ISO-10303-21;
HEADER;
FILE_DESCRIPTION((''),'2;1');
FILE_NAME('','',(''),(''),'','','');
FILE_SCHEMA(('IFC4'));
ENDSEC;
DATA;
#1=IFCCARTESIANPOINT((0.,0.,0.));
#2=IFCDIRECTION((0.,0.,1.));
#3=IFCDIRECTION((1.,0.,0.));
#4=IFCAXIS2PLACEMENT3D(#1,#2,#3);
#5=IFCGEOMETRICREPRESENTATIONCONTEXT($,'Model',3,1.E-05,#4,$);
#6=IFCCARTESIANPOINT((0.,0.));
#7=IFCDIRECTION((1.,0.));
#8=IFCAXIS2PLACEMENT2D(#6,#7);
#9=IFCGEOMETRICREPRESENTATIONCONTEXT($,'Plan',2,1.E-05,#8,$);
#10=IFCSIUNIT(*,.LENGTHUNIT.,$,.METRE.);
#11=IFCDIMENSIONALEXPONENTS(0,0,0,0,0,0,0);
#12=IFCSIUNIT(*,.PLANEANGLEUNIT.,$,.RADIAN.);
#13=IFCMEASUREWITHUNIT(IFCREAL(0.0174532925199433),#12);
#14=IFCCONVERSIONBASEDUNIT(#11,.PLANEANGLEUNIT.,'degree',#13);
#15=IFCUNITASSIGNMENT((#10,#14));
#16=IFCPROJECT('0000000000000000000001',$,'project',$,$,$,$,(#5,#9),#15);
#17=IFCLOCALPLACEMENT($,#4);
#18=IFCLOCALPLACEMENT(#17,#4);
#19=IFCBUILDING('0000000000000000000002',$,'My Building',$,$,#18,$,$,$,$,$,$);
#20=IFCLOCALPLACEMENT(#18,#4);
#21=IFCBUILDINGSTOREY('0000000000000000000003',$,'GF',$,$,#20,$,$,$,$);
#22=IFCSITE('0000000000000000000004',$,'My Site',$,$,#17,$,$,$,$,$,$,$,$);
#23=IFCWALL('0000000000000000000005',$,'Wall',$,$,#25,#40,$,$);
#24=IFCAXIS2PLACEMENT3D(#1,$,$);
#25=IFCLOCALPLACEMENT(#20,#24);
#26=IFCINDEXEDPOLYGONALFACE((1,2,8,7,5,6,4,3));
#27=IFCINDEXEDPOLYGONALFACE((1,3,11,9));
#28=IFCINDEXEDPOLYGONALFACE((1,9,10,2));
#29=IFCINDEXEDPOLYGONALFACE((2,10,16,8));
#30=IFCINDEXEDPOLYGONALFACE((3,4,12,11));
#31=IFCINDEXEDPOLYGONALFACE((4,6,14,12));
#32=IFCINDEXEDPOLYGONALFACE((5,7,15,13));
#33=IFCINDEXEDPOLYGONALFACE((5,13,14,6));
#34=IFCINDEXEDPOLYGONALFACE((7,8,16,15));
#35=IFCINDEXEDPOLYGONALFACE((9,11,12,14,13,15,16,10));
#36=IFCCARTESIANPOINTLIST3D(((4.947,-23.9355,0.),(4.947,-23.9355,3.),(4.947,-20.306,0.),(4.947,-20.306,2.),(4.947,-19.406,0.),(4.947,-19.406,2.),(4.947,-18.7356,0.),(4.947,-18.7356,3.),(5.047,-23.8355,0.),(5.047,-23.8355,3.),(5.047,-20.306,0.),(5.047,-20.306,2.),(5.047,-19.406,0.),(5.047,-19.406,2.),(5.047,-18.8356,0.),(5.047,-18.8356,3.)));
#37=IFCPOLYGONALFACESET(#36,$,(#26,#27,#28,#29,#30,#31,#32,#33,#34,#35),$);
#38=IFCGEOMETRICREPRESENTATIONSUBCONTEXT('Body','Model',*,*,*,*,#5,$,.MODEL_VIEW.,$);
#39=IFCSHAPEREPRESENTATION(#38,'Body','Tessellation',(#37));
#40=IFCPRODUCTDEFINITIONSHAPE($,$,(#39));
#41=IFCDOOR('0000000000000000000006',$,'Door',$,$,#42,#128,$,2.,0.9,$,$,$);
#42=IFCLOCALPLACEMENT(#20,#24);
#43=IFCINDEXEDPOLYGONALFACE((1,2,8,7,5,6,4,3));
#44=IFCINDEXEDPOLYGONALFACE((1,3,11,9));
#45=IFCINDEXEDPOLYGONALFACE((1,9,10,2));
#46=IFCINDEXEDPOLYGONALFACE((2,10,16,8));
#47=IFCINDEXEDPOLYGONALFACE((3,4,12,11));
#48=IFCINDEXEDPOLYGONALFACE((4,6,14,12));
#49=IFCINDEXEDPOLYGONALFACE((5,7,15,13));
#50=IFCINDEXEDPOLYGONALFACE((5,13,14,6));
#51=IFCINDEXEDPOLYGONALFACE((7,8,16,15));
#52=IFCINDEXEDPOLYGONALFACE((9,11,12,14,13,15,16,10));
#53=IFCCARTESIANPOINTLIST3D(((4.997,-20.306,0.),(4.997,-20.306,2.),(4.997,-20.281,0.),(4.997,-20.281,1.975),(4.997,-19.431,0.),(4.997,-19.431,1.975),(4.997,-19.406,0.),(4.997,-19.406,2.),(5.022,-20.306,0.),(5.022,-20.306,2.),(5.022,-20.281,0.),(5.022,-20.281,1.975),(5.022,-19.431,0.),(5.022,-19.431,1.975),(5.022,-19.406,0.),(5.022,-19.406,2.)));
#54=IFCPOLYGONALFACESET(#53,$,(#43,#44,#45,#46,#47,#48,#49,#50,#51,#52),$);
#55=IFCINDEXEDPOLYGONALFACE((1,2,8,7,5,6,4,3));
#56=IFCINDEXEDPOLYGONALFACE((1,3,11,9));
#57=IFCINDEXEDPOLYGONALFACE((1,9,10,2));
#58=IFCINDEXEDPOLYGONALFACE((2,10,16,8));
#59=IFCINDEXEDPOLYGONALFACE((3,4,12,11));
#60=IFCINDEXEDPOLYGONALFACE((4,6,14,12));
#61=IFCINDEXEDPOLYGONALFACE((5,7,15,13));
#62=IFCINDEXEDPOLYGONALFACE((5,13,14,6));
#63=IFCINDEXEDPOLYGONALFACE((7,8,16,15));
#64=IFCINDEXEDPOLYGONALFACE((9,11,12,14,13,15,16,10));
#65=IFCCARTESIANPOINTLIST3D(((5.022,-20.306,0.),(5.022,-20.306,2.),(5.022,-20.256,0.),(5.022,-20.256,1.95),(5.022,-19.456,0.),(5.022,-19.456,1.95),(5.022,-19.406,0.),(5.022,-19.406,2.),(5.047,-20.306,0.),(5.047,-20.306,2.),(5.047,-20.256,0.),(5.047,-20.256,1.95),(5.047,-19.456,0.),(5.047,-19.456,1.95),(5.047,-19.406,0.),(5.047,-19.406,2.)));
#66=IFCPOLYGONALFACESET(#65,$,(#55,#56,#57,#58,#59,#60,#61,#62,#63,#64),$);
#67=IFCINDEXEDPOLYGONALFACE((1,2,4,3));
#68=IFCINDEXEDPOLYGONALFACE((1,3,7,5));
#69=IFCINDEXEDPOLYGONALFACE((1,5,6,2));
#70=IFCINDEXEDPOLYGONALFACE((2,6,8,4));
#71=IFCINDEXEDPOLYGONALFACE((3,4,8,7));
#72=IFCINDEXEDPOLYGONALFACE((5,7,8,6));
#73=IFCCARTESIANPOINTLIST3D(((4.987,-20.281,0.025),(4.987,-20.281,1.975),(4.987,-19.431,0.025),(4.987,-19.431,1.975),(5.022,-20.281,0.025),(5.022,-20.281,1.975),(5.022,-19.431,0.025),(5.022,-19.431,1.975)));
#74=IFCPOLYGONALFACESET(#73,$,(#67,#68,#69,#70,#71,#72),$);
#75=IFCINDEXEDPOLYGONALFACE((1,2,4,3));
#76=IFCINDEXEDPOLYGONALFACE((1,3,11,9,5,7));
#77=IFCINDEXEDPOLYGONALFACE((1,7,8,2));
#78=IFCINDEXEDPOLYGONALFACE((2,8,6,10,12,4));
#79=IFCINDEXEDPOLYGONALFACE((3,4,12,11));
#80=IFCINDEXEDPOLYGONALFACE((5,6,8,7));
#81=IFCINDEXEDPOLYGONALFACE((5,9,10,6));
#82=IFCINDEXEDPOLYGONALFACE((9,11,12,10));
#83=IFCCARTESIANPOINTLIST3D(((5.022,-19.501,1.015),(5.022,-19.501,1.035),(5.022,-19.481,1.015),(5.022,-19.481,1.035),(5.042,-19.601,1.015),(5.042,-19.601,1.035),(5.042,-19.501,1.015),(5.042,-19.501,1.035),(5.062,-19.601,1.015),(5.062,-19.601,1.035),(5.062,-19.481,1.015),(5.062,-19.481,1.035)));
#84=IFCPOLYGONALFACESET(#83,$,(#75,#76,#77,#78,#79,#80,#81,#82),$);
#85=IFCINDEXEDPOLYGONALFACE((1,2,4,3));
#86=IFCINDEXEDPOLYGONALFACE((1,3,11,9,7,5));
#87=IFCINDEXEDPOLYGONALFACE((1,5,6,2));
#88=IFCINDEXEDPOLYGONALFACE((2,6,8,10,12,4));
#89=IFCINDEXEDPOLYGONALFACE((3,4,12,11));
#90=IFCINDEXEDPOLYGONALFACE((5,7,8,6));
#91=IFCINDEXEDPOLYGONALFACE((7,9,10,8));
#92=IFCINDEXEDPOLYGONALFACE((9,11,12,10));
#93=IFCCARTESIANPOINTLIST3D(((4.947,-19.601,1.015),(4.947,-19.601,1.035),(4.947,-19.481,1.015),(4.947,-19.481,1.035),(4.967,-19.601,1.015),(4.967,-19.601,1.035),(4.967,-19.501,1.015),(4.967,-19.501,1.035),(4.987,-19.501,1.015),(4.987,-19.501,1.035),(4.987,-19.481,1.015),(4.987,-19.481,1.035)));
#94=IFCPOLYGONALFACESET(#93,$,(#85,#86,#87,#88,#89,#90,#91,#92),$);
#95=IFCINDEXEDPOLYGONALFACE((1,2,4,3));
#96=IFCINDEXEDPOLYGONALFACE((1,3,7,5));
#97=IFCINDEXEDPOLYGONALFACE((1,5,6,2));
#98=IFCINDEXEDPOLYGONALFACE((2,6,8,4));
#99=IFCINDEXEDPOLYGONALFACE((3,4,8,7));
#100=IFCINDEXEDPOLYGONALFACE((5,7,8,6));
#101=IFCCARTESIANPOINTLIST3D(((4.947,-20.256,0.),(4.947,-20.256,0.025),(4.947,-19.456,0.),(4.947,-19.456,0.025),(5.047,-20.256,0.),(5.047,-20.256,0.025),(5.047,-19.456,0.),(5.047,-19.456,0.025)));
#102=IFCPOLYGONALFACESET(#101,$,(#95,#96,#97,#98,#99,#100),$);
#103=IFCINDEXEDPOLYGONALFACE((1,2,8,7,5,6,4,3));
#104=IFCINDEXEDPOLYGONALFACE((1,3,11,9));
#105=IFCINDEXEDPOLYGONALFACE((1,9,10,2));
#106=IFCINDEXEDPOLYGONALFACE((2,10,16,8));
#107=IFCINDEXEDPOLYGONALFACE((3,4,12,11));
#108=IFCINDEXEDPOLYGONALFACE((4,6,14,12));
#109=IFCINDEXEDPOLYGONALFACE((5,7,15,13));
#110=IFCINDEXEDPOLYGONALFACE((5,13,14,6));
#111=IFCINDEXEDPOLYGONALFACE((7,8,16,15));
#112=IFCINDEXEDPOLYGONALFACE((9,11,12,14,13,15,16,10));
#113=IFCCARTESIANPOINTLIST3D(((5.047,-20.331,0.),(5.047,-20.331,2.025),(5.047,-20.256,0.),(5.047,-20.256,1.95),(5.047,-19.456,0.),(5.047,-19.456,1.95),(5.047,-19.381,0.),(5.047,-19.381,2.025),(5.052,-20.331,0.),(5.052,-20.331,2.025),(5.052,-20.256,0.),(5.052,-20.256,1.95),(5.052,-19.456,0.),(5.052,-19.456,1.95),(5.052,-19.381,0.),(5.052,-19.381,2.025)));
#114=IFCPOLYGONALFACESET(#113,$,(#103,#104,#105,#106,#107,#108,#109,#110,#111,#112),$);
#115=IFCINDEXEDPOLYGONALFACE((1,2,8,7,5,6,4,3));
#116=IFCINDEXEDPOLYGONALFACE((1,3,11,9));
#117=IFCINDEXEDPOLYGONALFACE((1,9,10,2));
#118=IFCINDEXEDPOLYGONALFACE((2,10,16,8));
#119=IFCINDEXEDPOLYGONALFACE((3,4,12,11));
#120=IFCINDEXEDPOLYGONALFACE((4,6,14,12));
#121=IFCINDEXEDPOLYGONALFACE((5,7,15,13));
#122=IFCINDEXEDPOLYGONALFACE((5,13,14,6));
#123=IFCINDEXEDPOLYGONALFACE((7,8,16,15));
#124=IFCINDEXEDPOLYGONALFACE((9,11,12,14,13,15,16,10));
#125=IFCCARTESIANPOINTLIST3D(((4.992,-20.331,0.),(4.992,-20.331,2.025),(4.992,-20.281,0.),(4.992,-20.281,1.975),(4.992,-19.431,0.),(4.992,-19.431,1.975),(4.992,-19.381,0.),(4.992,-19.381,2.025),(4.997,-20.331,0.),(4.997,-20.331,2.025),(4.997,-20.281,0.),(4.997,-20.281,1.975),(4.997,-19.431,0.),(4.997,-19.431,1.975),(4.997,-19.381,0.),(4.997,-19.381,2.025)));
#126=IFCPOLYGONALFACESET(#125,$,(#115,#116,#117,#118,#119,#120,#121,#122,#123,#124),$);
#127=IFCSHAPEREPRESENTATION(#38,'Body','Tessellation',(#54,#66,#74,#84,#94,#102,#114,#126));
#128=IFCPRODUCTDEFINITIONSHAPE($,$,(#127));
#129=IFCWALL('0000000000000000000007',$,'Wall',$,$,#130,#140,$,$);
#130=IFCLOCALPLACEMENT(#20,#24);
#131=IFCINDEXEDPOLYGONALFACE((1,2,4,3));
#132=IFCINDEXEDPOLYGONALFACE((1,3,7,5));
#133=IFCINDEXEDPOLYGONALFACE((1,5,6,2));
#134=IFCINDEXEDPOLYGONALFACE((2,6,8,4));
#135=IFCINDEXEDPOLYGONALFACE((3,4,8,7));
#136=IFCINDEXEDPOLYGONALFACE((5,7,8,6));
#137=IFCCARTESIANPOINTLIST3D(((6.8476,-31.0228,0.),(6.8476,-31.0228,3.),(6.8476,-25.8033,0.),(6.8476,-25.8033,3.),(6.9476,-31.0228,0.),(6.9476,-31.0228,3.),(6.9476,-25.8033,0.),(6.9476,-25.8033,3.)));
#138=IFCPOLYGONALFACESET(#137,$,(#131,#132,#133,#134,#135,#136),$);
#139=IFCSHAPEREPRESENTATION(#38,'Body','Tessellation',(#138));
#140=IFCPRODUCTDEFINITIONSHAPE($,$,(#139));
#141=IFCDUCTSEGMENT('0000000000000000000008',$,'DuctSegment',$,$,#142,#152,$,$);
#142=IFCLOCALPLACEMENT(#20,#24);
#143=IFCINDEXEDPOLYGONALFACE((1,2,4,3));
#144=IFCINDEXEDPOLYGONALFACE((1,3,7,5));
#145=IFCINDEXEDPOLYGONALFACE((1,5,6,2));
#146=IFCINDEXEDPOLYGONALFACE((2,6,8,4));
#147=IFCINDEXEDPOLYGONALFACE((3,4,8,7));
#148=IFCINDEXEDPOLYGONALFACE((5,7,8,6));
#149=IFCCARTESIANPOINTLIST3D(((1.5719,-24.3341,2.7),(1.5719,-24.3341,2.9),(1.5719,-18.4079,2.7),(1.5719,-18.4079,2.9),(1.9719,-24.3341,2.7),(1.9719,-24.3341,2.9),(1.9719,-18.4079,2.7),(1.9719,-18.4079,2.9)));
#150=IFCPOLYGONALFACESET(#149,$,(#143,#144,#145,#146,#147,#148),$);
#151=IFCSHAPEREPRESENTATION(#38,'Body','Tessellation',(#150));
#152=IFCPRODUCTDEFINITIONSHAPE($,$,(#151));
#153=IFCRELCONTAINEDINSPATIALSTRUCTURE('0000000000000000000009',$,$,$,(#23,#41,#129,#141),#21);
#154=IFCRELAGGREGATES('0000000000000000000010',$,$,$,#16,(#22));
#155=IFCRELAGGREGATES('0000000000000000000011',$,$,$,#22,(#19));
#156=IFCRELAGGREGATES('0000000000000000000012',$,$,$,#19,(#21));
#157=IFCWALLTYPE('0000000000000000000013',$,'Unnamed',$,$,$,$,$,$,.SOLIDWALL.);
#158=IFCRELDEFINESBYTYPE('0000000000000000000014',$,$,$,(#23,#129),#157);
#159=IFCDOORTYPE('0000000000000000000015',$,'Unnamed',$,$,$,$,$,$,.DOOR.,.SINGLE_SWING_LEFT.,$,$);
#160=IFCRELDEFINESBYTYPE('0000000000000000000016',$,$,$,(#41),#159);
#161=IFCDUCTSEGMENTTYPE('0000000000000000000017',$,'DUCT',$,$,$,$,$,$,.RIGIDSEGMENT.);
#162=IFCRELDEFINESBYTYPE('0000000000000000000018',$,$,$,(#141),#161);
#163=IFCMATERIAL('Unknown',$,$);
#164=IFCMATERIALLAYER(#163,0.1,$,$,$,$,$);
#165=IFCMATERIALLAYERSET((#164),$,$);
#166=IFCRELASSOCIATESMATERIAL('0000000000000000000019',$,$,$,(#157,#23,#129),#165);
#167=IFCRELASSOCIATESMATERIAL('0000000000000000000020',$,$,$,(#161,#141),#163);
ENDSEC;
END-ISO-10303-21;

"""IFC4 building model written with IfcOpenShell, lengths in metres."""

from ifc_helpers import new_model, entity, si_unit, converted_unit, frame, origin_with_axes, origin_2d_with_axis, place, context, subcontext, project, spatial, line, indexed_curve, rectangle, outline, extrude, shape, source, transform, mapped, material, layer, layer_set, layer_usage, material_profile, profile_set, profile_usage, type_object, type_shapes, element, fill, save


model = new_model("IFC4")

# Units and contexts
model_context = context("Model", 3, precision=1e-05, world=origin_with_axes())
plan_context = context("Plan", 2, precision=1e-05, world=origin_2d_with_axis())
body_context_1 = subcontext(model_context, "Body", "Model", "MODEL_VIEW")
body_context_2 = subcontext(plan_context, "Body", "Plan", "PLAN_VIEW")
ifc_project = project(units=[si_unit("LENGTHUNIT", "METRE"), converted_unit("PLANEANGLEUNIT", "degree", entity("IfcReal", 0.0174532925199433), si_unit("PLANEANGLEUNIT", "RADIAN"), dimensions=[0, 0, 0, 0, 0, 0, 0])], contexts=[model_context, plan_context])

# Site, building, storey
site_placement = place(None, origin_with_axes())
site = spatial("IfcSite", under=ifc_project, at=site_placement, Name="My Site")
building_placement = place(site_placement, origin_with_axes())
building = spatial("IfcBuilding", under=site, at=building_placement, Name="My Building")
storey_placement = place(building_placement, origin_with_axes())
storey = spatial("IfcBuildingStorey", under=building, at=storey_placement, Name="GF")

# Shared definitions
ifc_material = material(Name="Unknown")

# Shared definitions
ifc_layer_1 = layer(ifc_material, 0.1)
ifc_layer_set_1 = layer_set([ifc_layer_1])
wall_type = type_object("IfcWallType", Name="Unnamed", PredefinedType="SOLIDWALL", material=ifc_layer_set_1)

# Shared definitions
shared_shape_1 = source(origin_with_axes(), body_context_1, "Body", "SweptSolid", [
    extrude(outline(indexed_curve([(0.0, 0.0), (0.9, 0.0), (0.9, 2.0), (0.0, 2.0)], segments=[line(1, 2, 3, 4, 1)])), frame((0.0, -0.6, 0.0), z_axis=(0.0, -1.0, 0.0), x_axis=(1.0, 0.0, 0.0)), (0.0, 0.0, -1.0), 1.2),
])
door_type = type_object("IfcDoorType", Name="Unnamed", OperationType="SINGLE_SWING_LEFT", PredefinedType="DOOR")
shared_shape_2 = source(origin_with_axes(), body_context_1, "Body", "SweptSolid", [
    extrude(outline(indexed_curve([(0.0, 0.0), (0.0, 2.0), (0.9, 2.0), (0.9, 0.0), (0.875, 0.0), (0.875, 1.975), (0.025, 1.975), (0.025, 0.0)], segments=[line(1, 2, 3, 4, 5, 6, 7, 8, 1)])), frame((0.0, 0.025, 0.0), z_axis=(0.0, -1.0, 0.0), x_axis=(1.0, 0.0, 0.0)), (0.0, 0.0, -1.0), 0.025),
    extrude(outline(indexed_curve([(0.0, 0.0), (0.0, 2.0), (0.9, 2.0), (0.9, 0.0), (0.85, 0.0), (0.85, 1.95), (0.05, 1.95), (0.05, 0.0)], segments=[line(1, 2, 3, 4, 5, 6, 7, 8, 1)])), frame((0.0, 0.0, 0.0), z_axis=(0.0, -1.0, 0.0), x_axis=(1.0, 0.0, 0.0)), (0.0, 0.0, -1.0), 0.025),
    extrude(outline(indexed_curve([(0.0, 0.0), (0.85, 0.0), (0.85, 0.035), (0.0, 0.035)], segments=[line(1, 2, 3, 4, 1)])), frame((0.025, 0.025, 0.025), z_axis=(0.0, 0.0, 1.0), x_axis=(1.0, 0.0, 0.0)), (0.0, 0.0, 1.0), 1.95),
    extrude(outline(indexed_curve([(0.0, 0.0), (0.0, -0.04), (-0.12, -0.04), (-0.12, -0.02), (-0.02, -0.02), (-0.02, 0.0)], segments=[line(1, 2, 3, 4, 5, 6, 1)])), frame((0.825, 0.025, 1.015), z_axis=(0.0, 0.0, 1.0), x_axis=(1.0, 0.0, 0.0)), (0.0, 0.0, 1.0), 0.02),
    extrude(outline(indexed_curve([(0.0, 0.0), (0.0, 0.04), (-0.12, 0.04), (-0.12, 0.02), (-0.02, 0.02), (-0.02, 0.0)], segments=[line(1, 2, 3, 4, 5, 6, 1)])), frame((0.825, 0.06, 1.015), z_axis=(0.0, 0.0, 1.0), x_axis=(1.0, 0.0, 0.0)), (0.0, 0.0, 1.0), 0.02),
    extrude(outline(indexed_curve([(0.0, 0.0), (0.8, 0.0), (0.8, 0.1), (0.0, 0.1)], segments=[line(1, 2, 3, 4, 1)])), frame((0.05, 0.0, 0.0), z_axis=(0.0, 0.0, 1.0), x_axis=(1.0, 0.0, 0.0)), (0.0, 0.0, 1.0), 0.025),
    extrude(outline(indexed_curve([(0.0, 0.0), (0.0, 2.025), (0.95, 2.025), (0.95, 0.0), (0.875, 0.0), (0.875, 1.95), (0.075, 1.95), (0.075, 0.0)], segments=[line(1, 2, 3, 4, 5, 6, 7, 8, 1)])), frame((-0.025, -0.005, 0.0), z_axis=(0.0, -1.0, 0.0), x_axis=(1.0, 0.0, 0.0)), (0.0, 0.0, -1.0), 0.005),
    extrude(outline(indexed_curve([(0.0, 0.0), (0.0, 2.025), (0.95, 2.025), (0.95, 0.0), (0.9, 0.0), (0.9, 1.975), (0.05, 1.975), (0.05, 0.0)], segments=[line(1, 2, 3, 4, 5, 6, 7, 8, 1)])), frame((-0.025, 0.05, 0.0), z_axis=(0.0, -1.0, 0.0), x_axis=(1.0, 0.0, 0.0)), (0.0, 0.0, -1.0), 0.005),
])
shared_shape_3 = source(origin_with_axes(), body_context_2, "Body", "Curve2D", [
    entity("IfcIndexedPolyCurve", entity("IfcCartesianPointList2D", [[0.0, 0.0], [0.0, 0.05], [0.025, 0.05], [0.025, 0.025], [0.05, 0.025], [0.05, 0.0]]), [entity("IfcLineIndex", [1, 2, 3, 4, 5, 6, 1])]),
    entity("IfcIndexedPolyCurve", entity("IfcCartesianPointList2D", [[0.9, 0.0], [0.9, 0.05], [0.875, 0.05], [0.875, 0.025], [0.85, 0.025], [0.85, 0.0]]), [entity("IfcLineIndex", [1, 2, 3, 4, 5, 6, 1])]),
    entity("IfcTrimmedCurve", entity("IfcEllipse", entity("IfcAxis2Placement2D", entity("IfcCartesianPoint", [0.06, 0.05]), entity("IfcDirection", [1.0, 0.0])), 0.815, 0.85), [entity("IfcCartesianPoint", [0.875, 0.05])], [entity("IfcCartesianPoint", [0.06, 0.9])], True, "CARTESIAN"),
    entity("IfcIndexedPolyCurve", entity("IfcCartesianPointList2D", [[0.025, 0.05], [0.06, 0.05], [0.06, 0.9], [0.025, 0.9]]), [entity("IfcLineIndex", [1, 2, 3, 4, 1])]),
])
type_shapes(door_type, [shared_shape_2, shared_shape_3])

# Wall, opening, door
ifc_layer_usage_1 = layer_usage(ifc_layer_set_1, "AXIS2", "POSITIVE", 0.0)
wall_1_placement = place(storey_placement, frame((5.047, -23.8355, 0.0), z_axis=(0.0, 0.0, 1.0), x_axis=(0.0, 1.0, 0.0)))
wall_1 = element("IfcWall", 1, at=wall_1_placement, inside=storey, type_object=wall_type, material=ifc_layer_usage_1, Name="Wall", context=body_context_1, shape_type="SweptSolid", body=[
    extrude(outline(indexed_curve([(0.0, 0.0), (-0.1, 0.1), (5.1, 0.1), (5.0, 0.0)], segments=[line(1, 2, 3, 4, 1)])), origin_with_axes(), (0.0, 0.0, 1.0), 3.0),
])
opening_1_placement = place(wall_1_placement, frame((3.5295, 0.0, 0.0), z_axis=(0.0, 0.0, 1.0), x_axis=(1.0, 0.0, 0.0)))
opening_1 = element("IfcOpeningElement", 2, at=opening_1_placement, cuts=wall_1, PredefinedType="OPENING", context=body_context_1, shape_type="MappedRepresentation", body=[
    mapped(shared_shape_1, transform((0.0, 0.0, 0.0), x_axis=(1.0, 0.0, 0.0), y_axis=(0.0, 1.0, 0.0), z_axis=(0.0, 0.0, 1.0), scale=1.0)),
])
door_1_placement = place(opening_1_placement, frame((0.0, 0.0, 0.0), z_axis=(0.0, 0.0, 1.0), x_axis=(1.0, 0.0, 0.0)))
door_1 = element("IfcDoor", 3, at=door_1_placement, inside=storey, type_object=door_type, Name="Door", OverallHeight=2.0, OverallWidth=0.9, shapes=[
    shape(body_context_1, "Body", "MappedRepresentation", [mapped(shared_shape_2, transform((0.0, 0.0, 0.0), x_axis=(1.0, 0.0, 0.0), y_axis=(0.0, 1.0, 0.0), z_axis=(0.0, 0.0, 1.0), scale=1.0))]),
    shape(body_context_2, "Body", "MappedRepresentation", [mapped(shared_shape_3, transform((0.0, 0.0, 0.0), x_axis=(1.0, 0.0, 0.0), y_axis=(0.0, 1.0, 0.0), z_axis=(0.0, 0.0, 1.0), scale=1.0))]),
])
fill(opening_1, door_1)

# Wall
ifc_layer_usage_2 = layer_usage(ifc_layer_set_1, "AXIS2", "POSITIVE", 0.0)
wall_2_placement = place(storey_placement, frame((6.8476, -25.8033, 0.0), z_axis=(0.0, 0.0, 1.0), x_axis=(0.0, -1.0, 0.0)))
element("IfcWall", 4, at=wall_2_placement, inside=storey, type_object=wall_type, material=ifc_layer_usage_2, Name="Wall", context=body_context_1, shape_type="SweptSolid", body=[
    extrude(outline(indexed_curve([(0.0, 0.0), (0.0, 0.1), (5.2195, 0.1), (5.2195, 0.0)], segments=[line(1, 2, 3, 4, 1)])), origin_with_axes(), (0.0, 0.0, 1.0), 3.0),
])

# Duct segment
ifc_material_profile = material_profile(ifc_material, rectangle(XDim=0.4, YDim=0.2))
ifc_profile_set = profile_set([ifc_material_profile])
ifc_profile_usage = profile_usage(ifc_profile_set, cardinal=5)
duct_segment_type = type_object("IfcDuctSegmentType", Name="DUCT", PredefinedType="RIGIDSEGMENT", material=ifc_profile_set)
duct_segment_placement = place(storey_placement, frame((1.7719, -18.4079, 2.8), z_axis=(0.0, -1.0, 0.0), x_axis=(1.0, 0.0, 0.0)))
element("IfcDuctSegment", 5, at=duct_segment_placement, inside=storey, type_object=duct_segment_type, material=ifc_profile_usage, Name="DuctSegment", context=body_context_1, shape_type="SweptSolid", body=[
    extrude(rectangle(XDim=0.4, YDim=0.2), origin_with_axes(), (0.0, 0.0, 1.0), 5.9262),
])

save(model, "model.ifc")
